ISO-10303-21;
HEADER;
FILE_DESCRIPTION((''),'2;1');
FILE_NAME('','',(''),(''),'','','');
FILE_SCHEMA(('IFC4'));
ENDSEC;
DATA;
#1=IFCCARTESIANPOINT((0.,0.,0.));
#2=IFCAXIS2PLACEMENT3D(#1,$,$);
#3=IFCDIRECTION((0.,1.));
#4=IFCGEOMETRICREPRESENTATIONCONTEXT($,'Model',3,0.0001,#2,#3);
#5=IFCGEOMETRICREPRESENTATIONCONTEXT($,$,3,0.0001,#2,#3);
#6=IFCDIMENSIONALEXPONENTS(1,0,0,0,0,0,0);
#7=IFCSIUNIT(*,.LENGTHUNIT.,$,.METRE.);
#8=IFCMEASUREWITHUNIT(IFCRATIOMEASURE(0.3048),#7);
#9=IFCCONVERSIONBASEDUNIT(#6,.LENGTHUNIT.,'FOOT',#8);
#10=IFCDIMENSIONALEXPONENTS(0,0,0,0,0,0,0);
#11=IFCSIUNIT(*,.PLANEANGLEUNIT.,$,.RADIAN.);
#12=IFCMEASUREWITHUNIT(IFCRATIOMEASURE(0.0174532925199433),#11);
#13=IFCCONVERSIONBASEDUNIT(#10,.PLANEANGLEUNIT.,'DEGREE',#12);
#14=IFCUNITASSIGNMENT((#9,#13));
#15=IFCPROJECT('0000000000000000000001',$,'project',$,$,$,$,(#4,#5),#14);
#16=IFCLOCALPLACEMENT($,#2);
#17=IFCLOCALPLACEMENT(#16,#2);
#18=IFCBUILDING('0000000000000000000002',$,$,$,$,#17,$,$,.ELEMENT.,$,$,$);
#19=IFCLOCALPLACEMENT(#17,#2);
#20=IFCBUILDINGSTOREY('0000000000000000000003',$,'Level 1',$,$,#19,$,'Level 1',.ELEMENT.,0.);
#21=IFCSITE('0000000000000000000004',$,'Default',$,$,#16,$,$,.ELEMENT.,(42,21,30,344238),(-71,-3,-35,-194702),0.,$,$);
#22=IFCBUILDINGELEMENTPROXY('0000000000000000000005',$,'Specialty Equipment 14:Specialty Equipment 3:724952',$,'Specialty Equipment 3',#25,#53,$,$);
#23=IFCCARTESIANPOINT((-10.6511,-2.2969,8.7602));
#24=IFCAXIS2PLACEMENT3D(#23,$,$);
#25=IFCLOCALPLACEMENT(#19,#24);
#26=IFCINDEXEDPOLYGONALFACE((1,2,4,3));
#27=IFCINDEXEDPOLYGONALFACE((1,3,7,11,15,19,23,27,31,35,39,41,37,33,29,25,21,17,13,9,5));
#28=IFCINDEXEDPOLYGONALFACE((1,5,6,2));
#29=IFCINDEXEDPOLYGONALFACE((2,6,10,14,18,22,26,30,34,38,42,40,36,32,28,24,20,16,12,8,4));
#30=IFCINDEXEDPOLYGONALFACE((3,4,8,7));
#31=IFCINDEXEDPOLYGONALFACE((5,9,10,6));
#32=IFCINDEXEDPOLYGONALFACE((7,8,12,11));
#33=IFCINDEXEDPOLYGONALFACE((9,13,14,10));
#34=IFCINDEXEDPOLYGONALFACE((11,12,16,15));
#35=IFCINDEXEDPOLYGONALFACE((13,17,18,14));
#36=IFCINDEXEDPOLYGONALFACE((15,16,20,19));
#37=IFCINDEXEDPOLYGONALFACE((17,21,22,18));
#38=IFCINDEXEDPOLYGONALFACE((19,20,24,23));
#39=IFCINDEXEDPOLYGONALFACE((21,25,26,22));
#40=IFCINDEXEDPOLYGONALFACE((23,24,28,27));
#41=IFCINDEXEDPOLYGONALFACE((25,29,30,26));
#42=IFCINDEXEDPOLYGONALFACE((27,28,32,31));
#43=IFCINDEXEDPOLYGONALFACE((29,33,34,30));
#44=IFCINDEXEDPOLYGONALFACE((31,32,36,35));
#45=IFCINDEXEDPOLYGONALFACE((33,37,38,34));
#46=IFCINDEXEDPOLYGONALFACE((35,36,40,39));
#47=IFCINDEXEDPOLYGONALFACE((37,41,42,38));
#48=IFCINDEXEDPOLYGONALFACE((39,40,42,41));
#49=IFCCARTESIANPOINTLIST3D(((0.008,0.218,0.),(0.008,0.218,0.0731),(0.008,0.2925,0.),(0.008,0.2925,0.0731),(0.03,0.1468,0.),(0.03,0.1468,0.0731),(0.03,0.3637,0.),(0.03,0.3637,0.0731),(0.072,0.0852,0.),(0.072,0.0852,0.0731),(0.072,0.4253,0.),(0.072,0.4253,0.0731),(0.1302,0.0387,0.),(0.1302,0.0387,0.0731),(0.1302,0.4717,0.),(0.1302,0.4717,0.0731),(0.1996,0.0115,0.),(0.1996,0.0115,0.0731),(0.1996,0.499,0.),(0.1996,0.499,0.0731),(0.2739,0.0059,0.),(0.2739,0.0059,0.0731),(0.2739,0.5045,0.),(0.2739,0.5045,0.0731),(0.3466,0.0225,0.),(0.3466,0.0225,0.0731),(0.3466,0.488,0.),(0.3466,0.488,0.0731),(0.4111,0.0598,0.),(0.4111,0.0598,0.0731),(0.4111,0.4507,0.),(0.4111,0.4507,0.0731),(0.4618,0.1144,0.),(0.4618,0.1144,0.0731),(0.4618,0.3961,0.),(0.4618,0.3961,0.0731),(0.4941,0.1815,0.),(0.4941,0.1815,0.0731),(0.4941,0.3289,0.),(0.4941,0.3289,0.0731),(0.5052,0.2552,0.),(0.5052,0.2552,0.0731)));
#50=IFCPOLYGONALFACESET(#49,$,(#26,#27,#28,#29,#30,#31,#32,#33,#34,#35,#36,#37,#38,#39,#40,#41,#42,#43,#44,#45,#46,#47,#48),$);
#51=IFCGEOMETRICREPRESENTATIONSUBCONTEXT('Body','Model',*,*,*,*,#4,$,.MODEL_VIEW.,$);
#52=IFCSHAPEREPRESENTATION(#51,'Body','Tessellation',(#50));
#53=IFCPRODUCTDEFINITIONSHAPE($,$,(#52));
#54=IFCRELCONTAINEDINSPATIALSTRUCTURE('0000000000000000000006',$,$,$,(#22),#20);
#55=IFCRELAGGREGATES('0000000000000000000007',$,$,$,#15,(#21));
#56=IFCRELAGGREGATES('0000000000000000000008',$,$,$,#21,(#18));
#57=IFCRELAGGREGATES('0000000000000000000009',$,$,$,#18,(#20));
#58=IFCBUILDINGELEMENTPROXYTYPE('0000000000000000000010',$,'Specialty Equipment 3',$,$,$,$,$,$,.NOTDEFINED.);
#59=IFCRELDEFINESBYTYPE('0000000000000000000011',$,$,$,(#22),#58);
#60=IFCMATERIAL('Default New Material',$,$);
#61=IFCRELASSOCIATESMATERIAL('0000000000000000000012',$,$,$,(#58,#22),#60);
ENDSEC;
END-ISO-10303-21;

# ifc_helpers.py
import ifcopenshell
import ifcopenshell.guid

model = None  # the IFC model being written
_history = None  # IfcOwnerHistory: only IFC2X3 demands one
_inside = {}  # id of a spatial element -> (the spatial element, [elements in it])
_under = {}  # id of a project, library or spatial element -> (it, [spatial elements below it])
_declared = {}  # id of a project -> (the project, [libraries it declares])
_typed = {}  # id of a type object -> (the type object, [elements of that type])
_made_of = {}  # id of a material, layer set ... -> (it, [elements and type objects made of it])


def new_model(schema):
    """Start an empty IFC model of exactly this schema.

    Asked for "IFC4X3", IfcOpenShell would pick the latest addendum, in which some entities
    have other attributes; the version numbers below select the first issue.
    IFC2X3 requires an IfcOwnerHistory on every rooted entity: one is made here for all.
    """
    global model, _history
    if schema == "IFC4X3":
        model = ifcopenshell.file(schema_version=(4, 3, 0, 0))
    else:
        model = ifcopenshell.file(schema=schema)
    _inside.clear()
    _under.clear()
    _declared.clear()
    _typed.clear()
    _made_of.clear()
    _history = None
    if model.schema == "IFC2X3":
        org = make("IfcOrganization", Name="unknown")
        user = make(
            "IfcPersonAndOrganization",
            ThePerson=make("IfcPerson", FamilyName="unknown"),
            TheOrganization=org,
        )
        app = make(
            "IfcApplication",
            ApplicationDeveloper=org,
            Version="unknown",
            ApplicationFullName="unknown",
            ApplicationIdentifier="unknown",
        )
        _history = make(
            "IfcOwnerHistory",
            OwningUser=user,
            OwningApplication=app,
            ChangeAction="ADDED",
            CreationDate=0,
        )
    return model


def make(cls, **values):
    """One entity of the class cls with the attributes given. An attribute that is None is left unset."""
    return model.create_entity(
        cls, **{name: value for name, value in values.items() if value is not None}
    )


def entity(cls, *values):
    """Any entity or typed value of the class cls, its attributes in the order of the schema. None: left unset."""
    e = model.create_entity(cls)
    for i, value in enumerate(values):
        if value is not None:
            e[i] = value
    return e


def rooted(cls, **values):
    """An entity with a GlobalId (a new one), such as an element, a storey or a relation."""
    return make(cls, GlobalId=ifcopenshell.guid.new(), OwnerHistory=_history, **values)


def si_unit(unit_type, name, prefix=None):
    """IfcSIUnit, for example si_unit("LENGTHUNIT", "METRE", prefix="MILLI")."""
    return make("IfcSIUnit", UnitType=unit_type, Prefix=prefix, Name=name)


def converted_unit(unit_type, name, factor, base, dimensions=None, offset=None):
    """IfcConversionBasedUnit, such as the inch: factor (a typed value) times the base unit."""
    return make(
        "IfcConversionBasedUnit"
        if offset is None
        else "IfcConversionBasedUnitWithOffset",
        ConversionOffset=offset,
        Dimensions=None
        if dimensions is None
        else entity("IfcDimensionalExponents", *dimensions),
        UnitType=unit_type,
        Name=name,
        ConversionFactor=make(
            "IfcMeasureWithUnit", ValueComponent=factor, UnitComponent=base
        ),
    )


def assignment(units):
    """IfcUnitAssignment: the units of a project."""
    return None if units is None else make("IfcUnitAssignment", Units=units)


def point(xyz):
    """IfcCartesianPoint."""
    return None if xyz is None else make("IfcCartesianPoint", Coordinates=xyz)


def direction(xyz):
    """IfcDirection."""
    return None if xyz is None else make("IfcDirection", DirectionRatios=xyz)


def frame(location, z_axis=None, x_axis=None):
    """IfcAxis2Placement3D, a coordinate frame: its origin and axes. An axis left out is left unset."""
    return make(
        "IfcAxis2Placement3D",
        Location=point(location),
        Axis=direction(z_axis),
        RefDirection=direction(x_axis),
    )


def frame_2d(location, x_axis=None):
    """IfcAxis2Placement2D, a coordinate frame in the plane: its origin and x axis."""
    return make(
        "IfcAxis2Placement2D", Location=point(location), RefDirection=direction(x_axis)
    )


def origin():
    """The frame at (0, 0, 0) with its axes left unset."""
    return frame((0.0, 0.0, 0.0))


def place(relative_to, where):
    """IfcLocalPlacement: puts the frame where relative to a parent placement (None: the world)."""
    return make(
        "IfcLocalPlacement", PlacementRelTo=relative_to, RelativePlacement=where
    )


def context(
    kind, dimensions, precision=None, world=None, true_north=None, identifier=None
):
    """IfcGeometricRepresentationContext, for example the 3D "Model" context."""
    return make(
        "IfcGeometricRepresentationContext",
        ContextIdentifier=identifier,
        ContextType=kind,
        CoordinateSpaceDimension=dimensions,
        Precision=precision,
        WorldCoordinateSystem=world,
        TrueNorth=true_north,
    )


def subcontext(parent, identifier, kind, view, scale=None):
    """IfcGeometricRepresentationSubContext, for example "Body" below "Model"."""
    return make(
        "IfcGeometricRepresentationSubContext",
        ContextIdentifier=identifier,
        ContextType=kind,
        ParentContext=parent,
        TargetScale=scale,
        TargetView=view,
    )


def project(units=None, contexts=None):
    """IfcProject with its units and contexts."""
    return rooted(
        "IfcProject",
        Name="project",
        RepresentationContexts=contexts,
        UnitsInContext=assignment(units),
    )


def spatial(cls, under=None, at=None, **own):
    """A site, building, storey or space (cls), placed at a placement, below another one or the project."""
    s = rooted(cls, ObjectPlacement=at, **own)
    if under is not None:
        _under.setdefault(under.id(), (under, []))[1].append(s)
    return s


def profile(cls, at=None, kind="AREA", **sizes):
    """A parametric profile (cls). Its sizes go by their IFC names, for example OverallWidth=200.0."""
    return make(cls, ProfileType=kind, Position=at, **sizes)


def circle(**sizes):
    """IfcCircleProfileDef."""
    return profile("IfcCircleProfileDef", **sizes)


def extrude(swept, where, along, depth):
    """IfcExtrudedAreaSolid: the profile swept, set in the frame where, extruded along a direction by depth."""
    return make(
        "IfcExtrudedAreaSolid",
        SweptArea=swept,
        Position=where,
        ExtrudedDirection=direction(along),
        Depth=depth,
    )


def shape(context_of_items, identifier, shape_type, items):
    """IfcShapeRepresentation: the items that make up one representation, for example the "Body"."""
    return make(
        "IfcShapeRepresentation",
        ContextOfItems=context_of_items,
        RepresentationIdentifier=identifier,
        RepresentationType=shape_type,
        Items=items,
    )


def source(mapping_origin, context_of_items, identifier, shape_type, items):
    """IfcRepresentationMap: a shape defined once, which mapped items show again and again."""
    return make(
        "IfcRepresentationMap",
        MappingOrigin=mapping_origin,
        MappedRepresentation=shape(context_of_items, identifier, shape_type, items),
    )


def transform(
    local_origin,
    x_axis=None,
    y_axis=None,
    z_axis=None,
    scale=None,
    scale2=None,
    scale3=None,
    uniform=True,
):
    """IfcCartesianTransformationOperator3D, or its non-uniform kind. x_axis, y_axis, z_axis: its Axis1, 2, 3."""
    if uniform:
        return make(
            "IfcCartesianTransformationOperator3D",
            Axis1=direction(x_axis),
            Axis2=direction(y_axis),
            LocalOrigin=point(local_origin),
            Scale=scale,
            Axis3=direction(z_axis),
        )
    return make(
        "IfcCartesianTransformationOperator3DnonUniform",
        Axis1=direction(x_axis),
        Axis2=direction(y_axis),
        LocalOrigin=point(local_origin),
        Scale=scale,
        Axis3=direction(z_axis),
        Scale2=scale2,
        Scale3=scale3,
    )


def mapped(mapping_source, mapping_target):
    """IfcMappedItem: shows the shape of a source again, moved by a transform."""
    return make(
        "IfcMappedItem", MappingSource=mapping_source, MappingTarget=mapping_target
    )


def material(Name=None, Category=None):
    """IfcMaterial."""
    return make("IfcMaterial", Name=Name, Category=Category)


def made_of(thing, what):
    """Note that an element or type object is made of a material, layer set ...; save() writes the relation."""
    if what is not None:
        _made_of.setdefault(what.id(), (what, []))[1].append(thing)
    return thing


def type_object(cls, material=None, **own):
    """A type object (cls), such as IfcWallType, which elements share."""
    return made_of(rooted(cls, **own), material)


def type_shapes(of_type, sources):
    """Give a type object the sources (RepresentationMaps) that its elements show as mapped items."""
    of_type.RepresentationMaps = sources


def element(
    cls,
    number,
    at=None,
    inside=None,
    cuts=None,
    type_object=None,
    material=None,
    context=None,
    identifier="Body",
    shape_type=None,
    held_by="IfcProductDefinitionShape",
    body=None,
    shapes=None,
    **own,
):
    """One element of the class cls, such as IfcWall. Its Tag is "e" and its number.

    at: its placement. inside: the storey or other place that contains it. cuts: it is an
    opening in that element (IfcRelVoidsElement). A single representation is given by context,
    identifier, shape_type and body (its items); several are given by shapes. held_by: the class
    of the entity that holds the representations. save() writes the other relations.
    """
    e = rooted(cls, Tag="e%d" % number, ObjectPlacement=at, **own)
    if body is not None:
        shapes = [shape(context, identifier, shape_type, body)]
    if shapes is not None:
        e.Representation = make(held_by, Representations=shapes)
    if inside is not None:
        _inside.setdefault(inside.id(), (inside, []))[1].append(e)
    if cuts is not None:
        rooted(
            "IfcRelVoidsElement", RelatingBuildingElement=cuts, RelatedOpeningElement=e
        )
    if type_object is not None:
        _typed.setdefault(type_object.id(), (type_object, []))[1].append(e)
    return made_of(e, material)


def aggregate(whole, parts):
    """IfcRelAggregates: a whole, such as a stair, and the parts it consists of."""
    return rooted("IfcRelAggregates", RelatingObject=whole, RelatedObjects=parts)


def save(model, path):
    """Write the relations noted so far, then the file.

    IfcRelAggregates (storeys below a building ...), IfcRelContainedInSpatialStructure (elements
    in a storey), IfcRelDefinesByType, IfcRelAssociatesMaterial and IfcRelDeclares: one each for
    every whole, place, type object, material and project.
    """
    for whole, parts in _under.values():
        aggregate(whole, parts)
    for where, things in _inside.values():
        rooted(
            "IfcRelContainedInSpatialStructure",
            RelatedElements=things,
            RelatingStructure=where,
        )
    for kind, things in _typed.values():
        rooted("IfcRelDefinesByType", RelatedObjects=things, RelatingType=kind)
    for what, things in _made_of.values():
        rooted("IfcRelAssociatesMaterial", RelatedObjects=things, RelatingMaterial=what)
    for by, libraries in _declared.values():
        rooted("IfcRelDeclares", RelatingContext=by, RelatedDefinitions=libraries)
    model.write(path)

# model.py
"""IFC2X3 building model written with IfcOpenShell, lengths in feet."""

from ifc_helpers import new_model, entity, si_unit, converted_unit, direction, frame, frame_2d, origin, place, context, subcontext, project, spatial, circle, extrude, source, transform, mapped, material, type_object, type_shapes, element, save


model = new_model("IFC2X3")

# Units and contexts
model_context = context("Model", 3, precision=0.0001, world=origin(), true_north=direction((0.0, 1.0)))
context_of_model = context(None, 3, precision=0.0001, world=origin(), true_north=direction((0.0, 1.0)))
body_context = subcontext(model_context, "Body", "Model", "MODEL_VIEW")
ifc_project = project(units=[converted_unit("LENGTHUNIT", "FOOT", entity("IfcRatioMeasure", 0.3048), si_unit("LENGTHUNIT", "METRE"), dimensions=[1, 0, 0, 0, 0, 0, 0]), converted_unit("PLANEANGLEUNIT", "DEGREE", entity("IfcRatioMeasure", 0.0174532925199433), si_unit("PLANEANGLEUNIT", "RADIAN"), dimensions=[0, 0, 0, 0, 0, 0, 0])], contexts=[model_context, context_of_model])

# Site, building, storey
site_placement = place(None, origin())
site = spatial("IfcSite", under=ifc_project, at=site_placement, Name="Default", CompositionType="ELEMENT", RefLatitude=(42, 21, 30, 344238), RefLongitude=(-71, -3, -35, -194702), RefElevation=0.0)
building_placement = place(site_placement, origin())
building = spatial("IfcBuilding", under=site, at=building_placement, CompositionType="ELEMENT")
storey_placement = place(building_placement, origin())
storey = spatial("IfcBuildingStorey", under=building, at=storey_placement, Name="Level 1", LongName="Level 1", CompositionType="ELEMENT", Elevation=0.0)

# Shared definitions
ifc_material_1 = material(Name="Default New Material")

# Building element proxy
building_element_proxy_type_1 = type_object("IfcBuildingElementProxyType", Name="Specialty Equipment 3", PredefinedType="NOTDEFINED", material=ifc_material_1)
shared_shape_1 = source(origin(), body_context, "Body", "SweptSolid", [
    extrude(circle(Radius=0.25, at=frame_2d((0.0, 0.0), x_axis=(1.0, 0.0))), frame((0.2552, 0.2552, 0.0)), (0.0, 0.0, 1.0), 0.0731),
])
type_shapes(building_element_proxy_type_1, [shared_shape_1])
proxy_1_placement = place(storey_placement, frame((-10.6511, -2.2969, 8.7602)))
element("IfcBuildingElementProxy", 1, at=proxy_1_placement, inside=storey, type_object=building_element_proxy_type_1, material=ifc_material_1, Name="Specialty Equipment 14:Specialty Equipment 3:724952", ObjectType="Specialty Equipment 3", context=body_context, shape_type="MappedRepresentation", body=[
    mapped(shared_shape_1, transform((0.0, 0.0, 0.0), scale=1.0)),
])

save(model, "model.ifc")
